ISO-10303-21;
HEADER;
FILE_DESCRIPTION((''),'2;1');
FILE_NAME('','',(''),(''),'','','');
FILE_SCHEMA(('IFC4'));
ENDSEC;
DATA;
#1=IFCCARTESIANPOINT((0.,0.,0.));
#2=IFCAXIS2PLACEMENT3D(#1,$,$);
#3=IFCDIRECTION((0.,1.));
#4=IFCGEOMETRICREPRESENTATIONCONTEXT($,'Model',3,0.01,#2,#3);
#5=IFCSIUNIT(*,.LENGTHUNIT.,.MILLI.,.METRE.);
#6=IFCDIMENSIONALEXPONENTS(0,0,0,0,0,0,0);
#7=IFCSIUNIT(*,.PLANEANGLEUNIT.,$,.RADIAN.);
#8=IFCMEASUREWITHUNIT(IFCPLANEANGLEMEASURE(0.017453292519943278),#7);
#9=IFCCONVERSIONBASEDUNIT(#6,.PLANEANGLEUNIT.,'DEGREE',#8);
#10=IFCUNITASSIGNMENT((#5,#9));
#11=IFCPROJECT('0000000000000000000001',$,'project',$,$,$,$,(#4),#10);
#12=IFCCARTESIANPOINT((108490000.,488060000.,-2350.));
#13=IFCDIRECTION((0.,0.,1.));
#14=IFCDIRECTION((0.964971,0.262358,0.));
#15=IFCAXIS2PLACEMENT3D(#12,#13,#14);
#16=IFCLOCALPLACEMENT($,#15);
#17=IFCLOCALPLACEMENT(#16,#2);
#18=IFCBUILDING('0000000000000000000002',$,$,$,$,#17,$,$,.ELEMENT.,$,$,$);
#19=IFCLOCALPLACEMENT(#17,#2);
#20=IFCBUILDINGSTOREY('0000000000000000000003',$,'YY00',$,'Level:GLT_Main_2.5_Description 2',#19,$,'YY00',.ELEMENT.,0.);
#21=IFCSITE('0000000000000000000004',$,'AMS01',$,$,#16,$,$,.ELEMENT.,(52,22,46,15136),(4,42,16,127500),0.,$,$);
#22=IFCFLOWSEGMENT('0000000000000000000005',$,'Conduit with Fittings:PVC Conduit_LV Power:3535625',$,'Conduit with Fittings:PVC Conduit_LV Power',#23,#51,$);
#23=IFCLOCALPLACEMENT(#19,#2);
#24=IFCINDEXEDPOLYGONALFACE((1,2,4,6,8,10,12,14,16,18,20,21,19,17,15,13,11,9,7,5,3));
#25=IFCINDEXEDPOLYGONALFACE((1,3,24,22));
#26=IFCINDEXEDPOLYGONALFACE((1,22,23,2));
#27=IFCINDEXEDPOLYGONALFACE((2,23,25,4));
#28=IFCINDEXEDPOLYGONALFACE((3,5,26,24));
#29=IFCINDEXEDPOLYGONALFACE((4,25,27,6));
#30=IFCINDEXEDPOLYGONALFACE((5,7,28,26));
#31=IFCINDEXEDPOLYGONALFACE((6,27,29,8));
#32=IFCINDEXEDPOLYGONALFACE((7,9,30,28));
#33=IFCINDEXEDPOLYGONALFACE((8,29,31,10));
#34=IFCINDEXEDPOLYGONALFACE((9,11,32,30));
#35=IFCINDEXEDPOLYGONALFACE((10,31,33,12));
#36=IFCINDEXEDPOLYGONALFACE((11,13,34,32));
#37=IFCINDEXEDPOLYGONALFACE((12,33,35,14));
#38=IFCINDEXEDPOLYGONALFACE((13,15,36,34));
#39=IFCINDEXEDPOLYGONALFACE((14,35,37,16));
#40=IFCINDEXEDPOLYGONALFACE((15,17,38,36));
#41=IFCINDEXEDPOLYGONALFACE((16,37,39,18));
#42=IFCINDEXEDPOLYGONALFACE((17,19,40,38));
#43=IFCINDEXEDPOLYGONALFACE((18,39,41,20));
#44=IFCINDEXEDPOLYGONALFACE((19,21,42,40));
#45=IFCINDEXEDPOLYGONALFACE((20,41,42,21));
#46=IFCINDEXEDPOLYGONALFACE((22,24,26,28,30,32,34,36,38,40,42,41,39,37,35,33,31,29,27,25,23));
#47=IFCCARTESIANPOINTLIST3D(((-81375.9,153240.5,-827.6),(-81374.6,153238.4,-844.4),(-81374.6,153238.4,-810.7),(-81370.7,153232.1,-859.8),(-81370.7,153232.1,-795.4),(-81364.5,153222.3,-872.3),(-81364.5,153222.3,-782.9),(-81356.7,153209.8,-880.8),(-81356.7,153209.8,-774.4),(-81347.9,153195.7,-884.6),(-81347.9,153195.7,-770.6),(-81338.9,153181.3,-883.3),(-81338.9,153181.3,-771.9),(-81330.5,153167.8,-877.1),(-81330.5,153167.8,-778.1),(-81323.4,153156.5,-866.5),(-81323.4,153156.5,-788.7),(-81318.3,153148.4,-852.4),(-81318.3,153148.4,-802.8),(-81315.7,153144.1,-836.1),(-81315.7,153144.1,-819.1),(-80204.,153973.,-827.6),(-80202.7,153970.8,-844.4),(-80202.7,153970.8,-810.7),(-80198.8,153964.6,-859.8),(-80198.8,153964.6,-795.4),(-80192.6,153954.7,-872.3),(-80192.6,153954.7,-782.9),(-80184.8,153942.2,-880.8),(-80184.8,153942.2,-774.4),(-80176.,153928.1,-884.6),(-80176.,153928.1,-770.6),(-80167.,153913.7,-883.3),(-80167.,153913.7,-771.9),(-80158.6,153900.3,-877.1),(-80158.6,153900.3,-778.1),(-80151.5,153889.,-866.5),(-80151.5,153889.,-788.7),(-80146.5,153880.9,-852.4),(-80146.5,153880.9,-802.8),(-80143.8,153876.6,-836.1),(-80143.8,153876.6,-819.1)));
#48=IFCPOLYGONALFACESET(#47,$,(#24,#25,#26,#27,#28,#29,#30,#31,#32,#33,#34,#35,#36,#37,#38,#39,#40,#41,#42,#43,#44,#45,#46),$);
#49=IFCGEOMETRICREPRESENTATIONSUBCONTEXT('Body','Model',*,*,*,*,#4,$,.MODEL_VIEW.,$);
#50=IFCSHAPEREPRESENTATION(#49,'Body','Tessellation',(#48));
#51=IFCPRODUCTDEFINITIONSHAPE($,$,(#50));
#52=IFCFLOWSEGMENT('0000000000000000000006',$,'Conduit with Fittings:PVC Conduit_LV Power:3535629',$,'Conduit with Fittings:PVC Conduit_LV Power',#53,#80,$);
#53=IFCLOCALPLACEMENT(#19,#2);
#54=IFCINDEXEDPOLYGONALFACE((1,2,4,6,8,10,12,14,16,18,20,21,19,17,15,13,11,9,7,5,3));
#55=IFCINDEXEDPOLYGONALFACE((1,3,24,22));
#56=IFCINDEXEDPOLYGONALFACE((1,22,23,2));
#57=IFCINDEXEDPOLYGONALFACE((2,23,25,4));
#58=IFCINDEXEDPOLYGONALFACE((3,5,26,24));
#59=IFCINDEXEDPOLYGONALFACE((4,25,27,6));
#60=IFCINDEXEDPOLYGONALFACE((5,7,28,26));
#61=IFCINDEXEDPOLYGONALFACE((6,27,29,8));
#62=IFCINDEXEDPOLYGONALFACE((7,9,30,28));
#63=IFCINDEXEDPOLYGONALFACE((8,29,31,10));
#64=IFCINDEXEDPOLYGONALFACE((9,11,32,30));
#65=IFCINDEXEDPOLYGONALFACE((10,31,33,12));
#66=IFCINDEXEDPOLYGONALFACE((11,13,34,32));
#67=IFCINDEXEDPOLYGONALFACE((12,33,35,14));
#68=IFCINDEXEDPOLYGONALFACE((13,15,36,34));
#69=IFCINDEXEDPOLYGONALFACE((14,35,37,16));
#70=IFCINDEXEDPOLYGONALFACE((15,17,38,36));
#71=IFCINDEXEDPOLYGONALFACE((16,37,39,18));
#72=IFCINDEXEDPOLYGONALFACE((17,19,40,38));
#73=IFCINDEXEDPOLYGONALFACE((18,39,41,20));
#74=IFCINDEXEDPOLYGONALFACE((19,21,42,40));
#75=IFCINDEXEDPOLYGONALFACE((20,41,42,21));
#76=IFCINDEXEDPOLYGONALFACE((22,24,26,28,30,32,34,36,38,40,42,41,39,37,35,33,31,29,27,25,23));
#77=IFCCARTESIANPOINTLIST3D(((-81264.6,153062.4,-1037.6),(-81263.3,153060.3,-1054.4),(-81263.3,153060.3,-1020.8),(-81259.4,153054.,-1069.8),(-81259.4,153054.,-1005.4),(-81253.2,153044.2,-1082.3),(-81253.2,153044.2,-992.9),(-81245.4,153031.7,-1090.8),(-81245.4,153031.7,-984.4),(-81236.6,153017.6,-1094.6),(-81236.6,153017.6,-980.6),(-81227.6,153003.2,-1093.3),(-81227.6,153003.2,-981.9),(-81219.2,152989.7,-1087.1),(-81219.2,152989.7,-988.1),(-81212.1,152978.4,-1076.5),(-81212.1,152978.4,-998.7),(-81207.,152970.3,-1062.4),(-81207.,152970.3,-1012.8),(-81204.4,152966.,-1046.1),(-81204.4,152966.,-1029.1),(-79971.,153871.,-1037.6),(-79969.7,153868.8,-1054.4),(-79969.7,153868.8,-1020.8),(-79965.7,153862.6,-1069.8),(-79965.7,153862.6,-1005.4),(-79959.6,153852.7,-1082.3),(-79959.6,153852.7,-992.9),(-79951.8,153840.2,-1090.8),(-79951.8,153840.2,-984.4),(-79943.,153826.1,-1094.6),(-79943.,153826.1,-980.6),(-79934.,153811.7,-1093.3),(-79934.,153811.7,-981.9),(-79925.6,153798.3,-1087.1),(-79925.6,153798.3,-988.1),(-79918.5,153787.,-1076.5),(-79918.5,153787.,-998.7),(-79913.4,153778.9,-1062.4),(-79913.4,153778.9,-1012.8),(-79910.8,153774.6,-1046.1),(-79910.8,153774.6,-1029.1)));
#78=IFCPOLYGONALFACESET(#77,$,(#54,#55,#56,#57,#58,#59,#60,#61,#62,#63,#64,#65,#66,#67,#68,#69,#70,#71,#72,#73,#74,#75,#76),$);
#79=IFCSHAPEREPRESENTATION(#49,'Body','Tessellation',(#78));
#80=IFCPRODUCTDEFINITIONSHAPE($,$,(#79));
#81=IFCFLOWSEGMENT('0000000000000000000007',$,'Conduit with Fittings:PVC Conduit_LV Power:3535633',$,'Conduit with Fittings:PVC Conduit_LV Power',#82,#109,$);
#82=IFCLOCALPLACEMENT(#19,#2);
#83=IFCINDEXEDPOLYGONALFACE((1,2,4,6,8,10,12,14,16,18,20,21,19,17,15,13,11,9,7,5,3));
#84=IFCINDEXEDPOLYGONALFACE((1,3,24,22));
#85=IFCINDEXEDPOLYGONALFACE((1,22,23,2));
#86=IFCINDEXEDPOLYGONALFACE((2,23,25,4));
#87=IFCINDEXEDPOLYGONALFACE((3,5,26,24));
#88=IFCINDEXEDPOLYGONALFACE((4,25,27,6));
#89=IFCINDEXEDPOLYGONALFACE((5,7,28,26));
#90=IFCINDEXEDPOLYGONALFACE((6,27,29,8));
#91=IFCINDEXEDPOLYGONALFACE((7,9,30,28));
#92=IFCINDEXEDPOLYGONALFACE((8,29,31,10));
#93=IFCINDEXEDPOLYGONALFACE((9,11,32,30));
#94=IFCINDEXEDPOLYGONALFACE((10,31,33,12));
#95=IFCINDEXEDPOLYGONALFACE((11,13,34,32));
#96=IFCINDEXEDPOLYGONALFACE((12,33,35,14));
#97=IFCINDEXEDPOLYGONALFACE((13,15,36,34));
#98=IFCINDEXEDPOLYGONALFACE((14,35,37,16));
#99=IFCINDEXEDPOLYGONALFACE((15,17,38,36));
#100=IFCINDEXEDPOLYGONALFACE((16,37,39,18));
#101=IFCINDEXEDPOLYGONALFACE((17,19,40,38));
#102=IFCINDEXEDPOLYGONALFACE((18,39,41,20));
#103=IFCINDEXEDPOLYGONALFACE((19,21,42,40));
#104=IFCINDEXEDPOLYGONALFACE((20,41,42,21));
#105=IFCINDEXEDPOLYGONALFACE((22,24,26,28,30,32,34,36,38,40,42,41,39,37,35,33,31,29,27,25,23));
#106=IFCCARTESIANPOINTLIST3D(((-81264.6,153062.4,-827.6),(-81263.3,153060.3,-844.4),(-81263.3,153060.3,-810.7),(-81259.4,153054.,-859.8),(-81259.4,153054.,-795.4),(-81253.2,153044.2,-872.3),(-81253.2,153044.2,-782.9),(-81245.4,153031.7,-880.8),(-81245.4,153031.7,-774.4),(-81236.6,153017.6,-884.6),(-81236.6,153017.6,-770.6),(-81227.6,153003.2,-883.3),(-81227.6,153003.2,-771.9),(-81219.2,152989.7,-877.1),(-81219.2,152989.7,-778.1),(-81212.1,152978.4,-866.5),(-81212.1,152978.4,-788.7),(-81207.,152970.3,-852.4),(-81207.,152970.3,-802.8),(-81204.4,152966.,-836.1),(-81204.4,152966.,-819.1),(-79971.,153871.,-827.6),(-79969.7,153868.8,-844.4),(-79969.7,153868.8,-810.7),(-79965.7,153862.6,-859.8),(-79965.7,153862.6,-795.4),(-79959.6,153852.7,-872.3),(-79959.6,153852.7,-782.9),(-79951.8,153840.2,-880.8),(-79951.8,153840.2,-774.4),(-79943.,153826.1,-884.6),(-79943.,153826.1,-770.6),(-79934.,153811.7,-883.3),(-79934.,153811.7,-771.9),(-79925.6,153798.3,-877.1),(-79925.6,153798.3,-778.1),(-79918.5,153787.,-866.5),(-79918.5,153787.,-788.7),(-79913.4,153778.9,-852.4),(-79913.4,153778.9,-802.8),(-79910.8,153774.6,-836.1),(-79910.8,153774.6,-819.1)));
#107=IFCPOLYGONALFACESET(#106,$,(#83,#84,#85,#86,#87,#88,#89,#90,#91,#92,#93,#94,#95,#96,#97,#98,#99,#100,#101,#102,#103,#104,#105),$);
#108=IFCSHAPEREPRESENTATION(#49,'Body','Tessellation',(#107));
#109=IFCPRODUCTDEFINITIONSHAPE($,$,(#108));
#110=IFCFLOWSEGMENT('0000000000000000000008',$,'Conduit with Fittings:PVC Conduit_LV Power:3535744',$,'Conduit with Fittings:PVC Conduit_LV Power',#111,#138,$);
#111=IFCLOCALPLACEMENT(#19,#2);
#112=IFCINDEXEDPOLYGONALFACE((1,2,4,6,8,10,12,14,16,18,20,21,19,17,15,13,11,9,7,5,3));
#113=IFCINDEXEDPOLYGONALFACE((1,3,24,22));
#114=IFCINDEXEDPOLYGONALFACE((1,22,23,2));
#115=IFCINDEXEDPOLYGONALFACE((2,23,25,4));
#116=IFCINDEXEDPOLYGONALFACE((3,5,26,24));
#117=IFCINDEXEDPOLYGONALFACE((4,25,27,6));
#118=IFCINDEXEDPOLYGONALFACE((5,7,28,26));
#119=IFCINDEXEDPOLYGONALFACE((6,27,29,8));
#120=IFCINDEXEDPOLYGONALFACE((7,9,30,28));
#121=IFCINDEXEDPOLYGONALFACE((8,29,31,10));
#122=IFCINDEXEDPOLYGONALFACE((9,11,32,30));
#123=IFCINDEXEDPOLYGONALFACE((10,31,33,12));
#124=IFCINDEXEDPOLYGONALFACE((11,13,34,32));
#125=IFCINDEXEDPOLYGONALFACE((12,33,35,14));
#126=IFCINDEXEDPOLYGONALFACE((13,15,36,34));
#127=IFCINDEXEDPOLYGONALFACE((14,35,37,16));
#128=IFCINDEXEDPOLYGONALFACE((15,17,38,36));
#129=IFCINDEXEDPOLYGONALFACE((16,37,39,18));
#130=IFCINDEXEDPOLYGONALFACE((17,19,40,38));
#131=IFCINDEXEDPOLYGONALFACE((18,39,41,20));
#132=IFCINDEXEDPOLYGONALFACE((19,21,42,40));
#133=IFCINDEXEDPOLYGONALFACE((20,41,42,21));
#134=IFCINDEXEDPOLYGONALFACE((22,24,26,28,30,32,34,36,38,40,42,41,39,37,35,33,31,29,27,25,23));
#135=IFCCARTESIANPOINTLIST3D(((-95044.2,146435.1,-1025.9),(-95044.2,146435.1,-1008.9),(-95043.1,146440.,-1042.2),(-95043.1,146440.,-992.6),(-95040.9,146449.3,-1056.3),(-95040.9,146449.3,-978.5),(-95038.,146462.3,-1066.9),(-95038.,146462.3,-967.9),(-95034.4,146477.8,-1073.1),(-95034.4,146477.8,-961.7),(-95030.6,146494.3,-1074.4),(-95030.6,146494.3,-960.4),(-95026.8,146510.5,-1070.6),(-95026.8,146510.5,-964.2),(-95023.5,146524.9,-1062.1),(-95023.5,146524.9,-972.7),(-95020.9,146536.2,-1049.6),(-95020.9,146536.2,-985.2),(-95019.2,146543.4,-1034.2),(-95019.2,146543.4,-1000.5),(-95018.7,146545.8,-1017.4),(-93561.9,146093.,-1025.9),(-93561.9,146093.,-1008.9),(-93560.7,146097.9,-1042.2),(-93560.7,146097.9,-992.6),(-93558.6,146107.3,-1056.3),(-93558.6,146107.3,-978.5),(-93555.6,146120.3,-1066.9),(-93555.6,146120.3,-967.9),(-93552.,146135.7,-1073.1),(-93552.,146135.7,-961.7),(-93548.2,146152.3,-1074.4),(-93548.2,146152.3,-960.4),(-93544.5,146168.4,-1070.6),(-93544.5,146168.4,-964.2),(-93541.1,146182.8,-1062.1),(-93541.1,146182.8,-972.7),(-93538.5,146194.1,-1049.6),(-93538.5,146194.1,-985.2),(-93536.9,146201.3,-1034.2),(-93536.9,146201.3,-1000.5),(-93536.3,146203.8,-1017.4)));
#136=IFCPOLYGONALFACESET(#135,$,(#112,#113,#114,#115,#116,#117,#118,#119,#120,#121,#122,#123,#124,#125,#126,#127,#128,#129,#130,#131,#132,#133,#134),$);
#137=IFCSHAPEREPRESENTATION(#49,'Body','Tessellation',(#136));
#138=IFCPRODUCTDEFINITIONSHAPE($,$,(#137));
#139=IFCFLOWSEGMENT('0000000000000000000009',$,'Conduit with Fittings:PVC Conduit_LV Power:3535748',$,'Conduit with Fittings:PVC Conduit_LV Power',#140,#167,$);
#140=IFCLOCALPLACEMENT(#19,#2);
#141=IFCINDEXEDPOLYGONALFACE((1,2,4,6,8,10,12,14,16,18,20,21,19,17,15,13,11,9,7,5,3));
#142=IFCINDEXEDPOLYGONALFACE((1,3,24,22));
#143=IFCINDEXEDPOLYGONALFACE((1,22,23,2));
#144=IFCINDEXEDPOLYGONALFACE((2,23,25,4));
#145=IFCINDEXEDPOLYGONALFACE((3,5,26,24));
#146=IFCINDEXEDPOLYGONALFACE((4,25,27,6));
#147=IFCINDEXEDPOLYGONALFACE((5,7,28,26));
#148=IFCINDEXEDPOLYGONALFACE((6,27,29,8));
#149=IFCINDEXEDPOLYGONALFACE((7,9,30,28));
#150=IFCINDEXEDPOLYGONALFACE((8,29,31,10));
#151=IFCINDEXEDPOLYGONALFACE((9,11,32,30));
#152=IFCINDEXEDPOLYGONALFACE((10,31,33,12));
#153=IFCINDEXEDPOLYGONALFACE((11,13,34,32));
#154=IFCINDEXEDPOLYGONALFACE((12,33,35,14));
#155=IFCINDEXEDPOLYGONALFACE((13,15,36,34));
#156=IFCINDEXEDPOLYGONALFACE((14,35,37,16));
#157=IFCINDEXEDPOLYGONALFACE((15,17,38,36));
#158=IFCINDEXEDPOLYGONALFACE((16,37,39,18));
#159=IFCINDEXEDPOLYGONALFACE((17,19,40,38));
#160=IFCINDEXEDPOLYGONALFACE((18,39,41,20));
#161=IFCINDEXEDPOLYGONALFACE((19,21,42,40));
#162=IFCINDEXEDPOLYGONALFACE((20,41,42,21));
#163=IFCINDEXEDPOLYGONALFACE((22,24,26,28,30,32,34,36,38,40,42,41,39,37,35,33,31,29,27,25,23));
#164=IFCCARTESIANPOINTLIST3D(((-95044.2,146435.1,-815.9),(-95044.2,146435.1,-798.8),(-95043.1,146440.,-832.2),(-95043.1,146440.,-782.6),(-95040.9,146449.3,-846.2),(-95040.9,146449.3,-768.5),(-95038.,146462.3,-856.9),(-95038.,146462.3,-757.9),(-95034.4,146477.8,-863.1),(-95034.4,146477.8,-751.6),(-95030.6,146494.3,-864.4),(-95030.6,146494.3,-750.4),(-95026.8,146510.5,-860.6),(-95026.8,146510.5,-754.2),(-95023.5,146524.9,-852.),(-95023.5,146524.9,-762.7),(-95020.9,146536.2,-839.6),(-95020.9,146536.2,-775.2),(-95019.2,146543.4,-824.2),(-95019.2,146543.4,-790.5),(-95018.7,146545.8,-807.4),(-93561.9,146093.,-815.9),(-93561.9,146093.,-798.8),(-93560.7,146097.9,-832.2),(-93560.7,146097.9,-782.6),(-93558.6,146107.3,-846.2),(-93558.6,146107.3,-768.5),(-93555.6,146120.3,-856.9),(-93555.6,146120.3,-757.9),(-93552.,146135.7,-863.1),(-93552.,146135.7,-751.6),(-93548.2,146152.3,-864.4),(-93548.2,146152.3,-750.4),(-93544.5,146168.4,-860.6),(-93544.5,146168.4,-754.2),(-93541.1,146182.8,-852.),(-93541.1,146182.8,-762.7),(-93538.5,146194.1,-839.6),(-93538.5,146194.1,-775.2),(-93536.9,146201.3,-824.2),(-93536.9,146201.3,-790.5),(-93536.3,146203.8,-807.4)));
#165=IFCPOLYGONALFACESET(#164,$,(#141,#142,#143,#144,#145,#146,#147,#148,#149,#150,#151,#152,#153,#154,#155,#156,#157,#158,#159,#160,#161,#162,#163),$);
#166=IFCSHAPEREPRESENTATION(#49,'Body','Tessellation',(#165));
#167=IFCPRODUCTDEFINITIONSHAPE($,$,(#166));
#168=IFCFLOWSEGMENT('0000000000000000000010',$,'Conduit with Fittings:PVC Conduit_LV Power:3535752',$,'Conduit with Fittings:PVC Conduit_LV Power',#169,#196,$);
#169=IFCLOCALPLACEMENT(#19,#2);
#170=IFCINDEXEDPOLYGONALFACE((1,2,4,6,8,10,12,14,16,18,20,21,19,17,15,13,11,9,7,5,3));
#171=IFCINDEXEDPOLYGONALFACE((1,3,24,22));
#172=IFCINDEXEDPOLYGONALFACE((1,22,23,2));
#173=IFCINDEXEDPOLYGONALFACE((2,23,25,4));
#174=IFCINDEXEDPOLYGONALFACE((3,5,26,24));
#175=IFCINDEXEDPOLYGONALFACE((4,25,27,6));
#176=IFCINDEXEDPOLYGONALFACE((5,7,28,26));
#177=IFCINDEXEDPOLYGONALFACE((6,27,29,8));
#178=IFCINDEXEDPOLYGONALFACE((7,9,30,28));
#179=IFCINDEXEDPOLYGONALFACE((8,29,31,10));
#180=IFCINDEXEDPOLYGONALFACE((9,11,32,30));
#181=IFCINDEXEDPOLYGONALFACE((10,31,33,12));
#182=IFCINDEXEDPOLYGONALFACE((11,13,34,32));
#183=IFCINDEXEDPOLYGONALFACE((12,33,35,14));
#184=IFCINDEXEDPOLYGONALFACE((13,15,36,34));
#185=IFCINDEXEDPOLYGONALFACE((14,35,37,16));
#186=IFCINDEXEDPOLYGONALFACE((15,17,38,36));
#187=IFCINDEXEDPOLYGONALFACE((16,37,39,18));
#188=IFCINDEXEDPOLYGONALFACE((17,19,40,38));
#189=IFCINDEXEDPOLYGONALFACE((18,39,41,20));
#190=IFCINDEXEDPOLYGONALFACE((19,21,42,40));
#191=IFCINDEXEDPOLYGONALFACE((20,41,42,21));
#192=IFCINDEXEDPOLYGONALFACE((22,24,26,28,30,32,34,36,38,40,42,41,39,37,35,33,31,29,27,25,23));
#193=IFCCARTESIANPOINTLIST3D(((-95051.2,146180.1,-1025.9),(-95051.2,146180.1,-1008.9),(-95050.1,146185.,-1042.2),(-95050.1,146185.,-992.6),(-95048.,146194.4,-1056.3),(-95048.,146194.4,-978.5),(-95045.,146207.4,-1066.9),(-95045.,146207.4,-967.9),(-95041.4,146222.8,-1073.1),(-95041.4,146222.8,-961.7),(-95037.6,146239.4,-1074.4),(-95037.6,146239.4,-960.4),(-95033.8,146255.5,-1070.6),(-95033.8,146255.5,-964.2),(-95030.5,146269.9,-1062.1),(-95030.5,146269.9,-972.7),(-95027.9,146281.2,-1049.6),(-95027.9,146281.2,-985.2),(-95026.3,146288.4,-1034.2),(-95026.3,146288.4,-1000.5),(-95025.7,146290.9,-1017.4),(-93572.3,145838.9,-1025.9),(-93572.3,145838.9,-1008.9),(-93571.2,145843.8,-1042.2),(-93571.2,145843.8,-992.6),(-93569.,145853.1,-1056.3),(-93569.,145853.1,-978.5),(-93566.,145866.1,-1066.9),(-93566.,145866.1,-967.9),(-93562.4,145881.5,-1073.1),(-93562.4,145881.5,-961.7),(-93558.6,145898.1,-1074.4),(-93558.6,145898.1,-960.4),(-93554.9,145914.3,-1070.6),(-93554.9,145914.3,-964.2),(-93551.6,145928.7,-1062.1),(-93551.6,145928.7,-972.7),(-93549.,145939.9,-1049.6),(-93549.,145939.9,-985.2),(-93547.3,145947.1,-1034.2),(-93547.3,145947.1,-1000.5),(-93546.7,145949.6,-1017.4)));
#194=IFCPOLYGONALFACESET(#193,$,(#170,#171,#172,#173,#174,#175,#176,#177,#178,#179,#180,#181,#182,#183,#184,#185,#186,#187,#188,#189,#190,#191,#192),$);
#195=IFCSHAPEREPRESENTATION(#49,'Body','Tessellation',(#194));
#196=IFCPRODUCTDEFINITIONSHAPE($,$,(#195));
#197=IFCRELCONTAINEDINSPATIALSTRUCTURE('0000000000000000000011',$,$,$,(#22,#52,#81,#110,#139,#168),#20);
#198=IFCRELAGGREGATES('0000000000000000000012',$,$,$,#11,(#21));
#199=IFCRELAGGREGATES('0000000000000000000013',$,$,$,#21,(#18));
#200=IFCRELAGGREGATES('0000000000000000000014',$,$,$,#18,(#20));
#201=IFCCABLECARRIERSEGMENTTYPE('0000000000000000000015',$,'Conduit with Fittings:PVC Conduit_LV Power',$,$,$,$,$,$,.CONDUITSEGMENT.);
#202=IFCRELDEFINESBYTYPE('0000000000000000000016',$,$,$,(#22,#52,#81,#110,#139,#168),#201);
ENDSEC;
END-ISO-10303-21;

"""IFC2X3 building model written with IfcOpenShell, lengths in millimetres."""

from ifc_helpers import new_model, entity, si_unit, converted_unit, direction, frame, frame_2d, origin, origin_2d_with_axis, place, context, subcontext, project, spatial, circle, extrude, type_object, element, save


model = new_model("IFC2X3")

# Units and contexts
model_context = context("Model", 3, precision=0.01, world=origin(), true_north=direction((0.0, 1.0)))
body_context = subcontext(model_context, "Body", "Model", "MODEL_VIEW")
ifc_project = project(units=[si_unit("LENGTHUNIT", "METRE", prefix="MILLI"), converted_unit("PLANEANGLEUNIT", "DEGREE", entity("IfcPlaneAngleMeasure", 0.017453292519943278), si_unit("PLANEANGLEUNIT", "RADIAN"), dimensions=[0, 0, 0, 0, 0, 0, 0])], contexts=[model_context])

# Site, building, storey
site_placement = place(None, frame((108490000.0, 488060000.0, -2350.0), z_axis=(0.0, 0.0, 1.0), x_axis=(0.964971, 0.262358, 0.0)))
site = spatial("IfcSite", under=ifc_project, at=site_placement, Name="AMS01", CompositionType="ELEMENT", RefLatitude=(52, 22, 46, 15136), RefLongitude=(4, 42, 16, 127500), RefElevation=0.0)
building_placement = place(site_placement, origin())
building = spatial("IfcBuilding", under=site, at=building_placement, CompositionType="ELEMENT")
storey_placement = place(building_placement, origin())
storey = spatial("IfcBuildingStorey", under=building, at=storey_placement, Name="YY00", ObjectType="Level:GLT_Main_2.5_Description 2", LongName="YY00", CompositionType="ELEMENT", Elevation=0.0)

# Flow segments
cable_carrier_segment_type = type_object("IfcCableCarrierSegmentType", Name="Conduit with Fittings:PVC Conduit_LV Power", PredefinedType="CONDUITSEGMENT")
flow_segment_1_placement = place(storey_placement, origin())
element("IfcFlowSegment", 1, at=flow_segment_1_placement, inside=storey, type_object=cable_carrier_segment_type, Name="Conduit with Fittings:PVC Conduit_LV Power:3535625", ObjectType="Conduit with Fittings:PVC Conduit_LV Power", context=body_context, shape_type="SweptSolid", body=[
    extrude(circle(Radius=57.2, at=frame_2d((0.0, 0.0), x_axis=(1.0, 0.0))), frame((-81345.6, 153192.0, -827.6), z_axis=(0.847987, 0.530017, 0.0), x_axis=(-0.530017, 0.847987, 0.0)), (0.0, 0.0, 1.0), 1382.0),
])
flow_segment_2_placement = place(storey_placement, origin())
element("IfcFlowSegment", 2, at=flow_segment_2_placement, inside=storey, type_object=cable_carrier_segment_type, Name="Conduit with Fittings:PVC Conduit_LV Power:3535629", ObjectType="Conduit with Fittings:PVC Conduit_LV Power", context=body_context, shape_type="SweptSolid", body=[
    extrude(circle(Radius=57.2, at=frame_2d((0.0, 0.0), x_axis=(1.0, 0.0))), frame((-81234.3, 153014.0, -1037.6), z_axis=(0.847987, 0.530017, 0.0), x_axis=(-0.530017, 0.847987, 0.0)), (0.0, 0.0, 1.0), 1525.5),
])
flow_segment_3_placement = place(storey_placement, origin())
element("IfcFlowSegment", 3, at=flow_segment_3_placement, inside=storey, type_object=cable_carrier_segment_type, Name="Conduit with Fittings:PVC Conduit_LV Power:3535633", ObjectType="Conduit with Fittings:PVC Conduit_LV Power", context=body_context, shape_type="SweptSolid", body=[
    extrude(circle(Radius=57.2, at=frame_2d((0.0, 0.0), x_axis=(1.0, 0.0))), frame((-81234.3, 153014.0, -827.6), z_axis=(0.847987, 0.530017, 0.0), x_axis=(-0.530017, 0.847987, 0.0)), (0.0, 0.0, 1.0), 1525.5),
])
flow_segment_4_placement = place(storey_placement, origin())
element("IfcFlowSegment", 4, at=flow_segment_4_placement, inside=storey, type_object=cable_carrier_segment_type, Name="Conduit with Fittings:PVC Conduit_LV Power:3535744", ObjectType="Conduit with Fittings:PVC Conduit_LV Power", context=body_context, shape_type="SweptSolid", body=[
    extrude(circle(Radius=57.2, at=origin_2d_with_axis()), frame((-93549.2, 146148.1, -1017.4), z_axis=(-0.974396, 0.224839, 0.0), x_axis=(0.224839, 0.974396, 0.0)), (0.0, 0.0, 1.0), 1521.3),
])
flow_segment_5_placement = place(storey_placement, origin())
element("IfcFlowSegment", 5, at=flow_segment_5_placement, inside=storey, type_object=cable_carrier_segment_type, Name="Conduit with Fittings:PVC Conduit_LV Power:3535748", ObjectType="Conduit with Fittings:PVC Conduit_LV Power", context=body_context, shape_type="SweptSolid", body=[
    extrude(circle(Radius=57.2, at=origin_2d_with_axis()), frame((-93549.2, 146148.1, -807.4), z_axis=(-0.974396, 0.224839, 0.0), x_axis=(0.224839, 0.974396, 0.0)), (0.0, 0.0, 1.0), 1521.3),
])
flow_segment_6_placement = place(storey_placement, origin())
element("IfcFlowSegment", 6, at=flow_segment_6_placement, inside=storey, type_object=cable_carrier_segment_type, Name="Conduit with Fittings:PVC Conduit_LV Power:3535752", ObjectType="Conduit with Fittings:PVC Conduit_LV Power", context=body_context, shape_type="SweptSolid", body=[
    extrude(circle(Radius=57.2, at=origin_2d_with_axis()), frame((-93559.6, 145893.9, -1017.4), z_axis=(-0.974396, 0.224839, 0.0), x_axis=(0.224839, 0.974396, 0.0)), (0.0, 0.0, 1.0), 1517.8),
])

save(model, "model.ifc")
